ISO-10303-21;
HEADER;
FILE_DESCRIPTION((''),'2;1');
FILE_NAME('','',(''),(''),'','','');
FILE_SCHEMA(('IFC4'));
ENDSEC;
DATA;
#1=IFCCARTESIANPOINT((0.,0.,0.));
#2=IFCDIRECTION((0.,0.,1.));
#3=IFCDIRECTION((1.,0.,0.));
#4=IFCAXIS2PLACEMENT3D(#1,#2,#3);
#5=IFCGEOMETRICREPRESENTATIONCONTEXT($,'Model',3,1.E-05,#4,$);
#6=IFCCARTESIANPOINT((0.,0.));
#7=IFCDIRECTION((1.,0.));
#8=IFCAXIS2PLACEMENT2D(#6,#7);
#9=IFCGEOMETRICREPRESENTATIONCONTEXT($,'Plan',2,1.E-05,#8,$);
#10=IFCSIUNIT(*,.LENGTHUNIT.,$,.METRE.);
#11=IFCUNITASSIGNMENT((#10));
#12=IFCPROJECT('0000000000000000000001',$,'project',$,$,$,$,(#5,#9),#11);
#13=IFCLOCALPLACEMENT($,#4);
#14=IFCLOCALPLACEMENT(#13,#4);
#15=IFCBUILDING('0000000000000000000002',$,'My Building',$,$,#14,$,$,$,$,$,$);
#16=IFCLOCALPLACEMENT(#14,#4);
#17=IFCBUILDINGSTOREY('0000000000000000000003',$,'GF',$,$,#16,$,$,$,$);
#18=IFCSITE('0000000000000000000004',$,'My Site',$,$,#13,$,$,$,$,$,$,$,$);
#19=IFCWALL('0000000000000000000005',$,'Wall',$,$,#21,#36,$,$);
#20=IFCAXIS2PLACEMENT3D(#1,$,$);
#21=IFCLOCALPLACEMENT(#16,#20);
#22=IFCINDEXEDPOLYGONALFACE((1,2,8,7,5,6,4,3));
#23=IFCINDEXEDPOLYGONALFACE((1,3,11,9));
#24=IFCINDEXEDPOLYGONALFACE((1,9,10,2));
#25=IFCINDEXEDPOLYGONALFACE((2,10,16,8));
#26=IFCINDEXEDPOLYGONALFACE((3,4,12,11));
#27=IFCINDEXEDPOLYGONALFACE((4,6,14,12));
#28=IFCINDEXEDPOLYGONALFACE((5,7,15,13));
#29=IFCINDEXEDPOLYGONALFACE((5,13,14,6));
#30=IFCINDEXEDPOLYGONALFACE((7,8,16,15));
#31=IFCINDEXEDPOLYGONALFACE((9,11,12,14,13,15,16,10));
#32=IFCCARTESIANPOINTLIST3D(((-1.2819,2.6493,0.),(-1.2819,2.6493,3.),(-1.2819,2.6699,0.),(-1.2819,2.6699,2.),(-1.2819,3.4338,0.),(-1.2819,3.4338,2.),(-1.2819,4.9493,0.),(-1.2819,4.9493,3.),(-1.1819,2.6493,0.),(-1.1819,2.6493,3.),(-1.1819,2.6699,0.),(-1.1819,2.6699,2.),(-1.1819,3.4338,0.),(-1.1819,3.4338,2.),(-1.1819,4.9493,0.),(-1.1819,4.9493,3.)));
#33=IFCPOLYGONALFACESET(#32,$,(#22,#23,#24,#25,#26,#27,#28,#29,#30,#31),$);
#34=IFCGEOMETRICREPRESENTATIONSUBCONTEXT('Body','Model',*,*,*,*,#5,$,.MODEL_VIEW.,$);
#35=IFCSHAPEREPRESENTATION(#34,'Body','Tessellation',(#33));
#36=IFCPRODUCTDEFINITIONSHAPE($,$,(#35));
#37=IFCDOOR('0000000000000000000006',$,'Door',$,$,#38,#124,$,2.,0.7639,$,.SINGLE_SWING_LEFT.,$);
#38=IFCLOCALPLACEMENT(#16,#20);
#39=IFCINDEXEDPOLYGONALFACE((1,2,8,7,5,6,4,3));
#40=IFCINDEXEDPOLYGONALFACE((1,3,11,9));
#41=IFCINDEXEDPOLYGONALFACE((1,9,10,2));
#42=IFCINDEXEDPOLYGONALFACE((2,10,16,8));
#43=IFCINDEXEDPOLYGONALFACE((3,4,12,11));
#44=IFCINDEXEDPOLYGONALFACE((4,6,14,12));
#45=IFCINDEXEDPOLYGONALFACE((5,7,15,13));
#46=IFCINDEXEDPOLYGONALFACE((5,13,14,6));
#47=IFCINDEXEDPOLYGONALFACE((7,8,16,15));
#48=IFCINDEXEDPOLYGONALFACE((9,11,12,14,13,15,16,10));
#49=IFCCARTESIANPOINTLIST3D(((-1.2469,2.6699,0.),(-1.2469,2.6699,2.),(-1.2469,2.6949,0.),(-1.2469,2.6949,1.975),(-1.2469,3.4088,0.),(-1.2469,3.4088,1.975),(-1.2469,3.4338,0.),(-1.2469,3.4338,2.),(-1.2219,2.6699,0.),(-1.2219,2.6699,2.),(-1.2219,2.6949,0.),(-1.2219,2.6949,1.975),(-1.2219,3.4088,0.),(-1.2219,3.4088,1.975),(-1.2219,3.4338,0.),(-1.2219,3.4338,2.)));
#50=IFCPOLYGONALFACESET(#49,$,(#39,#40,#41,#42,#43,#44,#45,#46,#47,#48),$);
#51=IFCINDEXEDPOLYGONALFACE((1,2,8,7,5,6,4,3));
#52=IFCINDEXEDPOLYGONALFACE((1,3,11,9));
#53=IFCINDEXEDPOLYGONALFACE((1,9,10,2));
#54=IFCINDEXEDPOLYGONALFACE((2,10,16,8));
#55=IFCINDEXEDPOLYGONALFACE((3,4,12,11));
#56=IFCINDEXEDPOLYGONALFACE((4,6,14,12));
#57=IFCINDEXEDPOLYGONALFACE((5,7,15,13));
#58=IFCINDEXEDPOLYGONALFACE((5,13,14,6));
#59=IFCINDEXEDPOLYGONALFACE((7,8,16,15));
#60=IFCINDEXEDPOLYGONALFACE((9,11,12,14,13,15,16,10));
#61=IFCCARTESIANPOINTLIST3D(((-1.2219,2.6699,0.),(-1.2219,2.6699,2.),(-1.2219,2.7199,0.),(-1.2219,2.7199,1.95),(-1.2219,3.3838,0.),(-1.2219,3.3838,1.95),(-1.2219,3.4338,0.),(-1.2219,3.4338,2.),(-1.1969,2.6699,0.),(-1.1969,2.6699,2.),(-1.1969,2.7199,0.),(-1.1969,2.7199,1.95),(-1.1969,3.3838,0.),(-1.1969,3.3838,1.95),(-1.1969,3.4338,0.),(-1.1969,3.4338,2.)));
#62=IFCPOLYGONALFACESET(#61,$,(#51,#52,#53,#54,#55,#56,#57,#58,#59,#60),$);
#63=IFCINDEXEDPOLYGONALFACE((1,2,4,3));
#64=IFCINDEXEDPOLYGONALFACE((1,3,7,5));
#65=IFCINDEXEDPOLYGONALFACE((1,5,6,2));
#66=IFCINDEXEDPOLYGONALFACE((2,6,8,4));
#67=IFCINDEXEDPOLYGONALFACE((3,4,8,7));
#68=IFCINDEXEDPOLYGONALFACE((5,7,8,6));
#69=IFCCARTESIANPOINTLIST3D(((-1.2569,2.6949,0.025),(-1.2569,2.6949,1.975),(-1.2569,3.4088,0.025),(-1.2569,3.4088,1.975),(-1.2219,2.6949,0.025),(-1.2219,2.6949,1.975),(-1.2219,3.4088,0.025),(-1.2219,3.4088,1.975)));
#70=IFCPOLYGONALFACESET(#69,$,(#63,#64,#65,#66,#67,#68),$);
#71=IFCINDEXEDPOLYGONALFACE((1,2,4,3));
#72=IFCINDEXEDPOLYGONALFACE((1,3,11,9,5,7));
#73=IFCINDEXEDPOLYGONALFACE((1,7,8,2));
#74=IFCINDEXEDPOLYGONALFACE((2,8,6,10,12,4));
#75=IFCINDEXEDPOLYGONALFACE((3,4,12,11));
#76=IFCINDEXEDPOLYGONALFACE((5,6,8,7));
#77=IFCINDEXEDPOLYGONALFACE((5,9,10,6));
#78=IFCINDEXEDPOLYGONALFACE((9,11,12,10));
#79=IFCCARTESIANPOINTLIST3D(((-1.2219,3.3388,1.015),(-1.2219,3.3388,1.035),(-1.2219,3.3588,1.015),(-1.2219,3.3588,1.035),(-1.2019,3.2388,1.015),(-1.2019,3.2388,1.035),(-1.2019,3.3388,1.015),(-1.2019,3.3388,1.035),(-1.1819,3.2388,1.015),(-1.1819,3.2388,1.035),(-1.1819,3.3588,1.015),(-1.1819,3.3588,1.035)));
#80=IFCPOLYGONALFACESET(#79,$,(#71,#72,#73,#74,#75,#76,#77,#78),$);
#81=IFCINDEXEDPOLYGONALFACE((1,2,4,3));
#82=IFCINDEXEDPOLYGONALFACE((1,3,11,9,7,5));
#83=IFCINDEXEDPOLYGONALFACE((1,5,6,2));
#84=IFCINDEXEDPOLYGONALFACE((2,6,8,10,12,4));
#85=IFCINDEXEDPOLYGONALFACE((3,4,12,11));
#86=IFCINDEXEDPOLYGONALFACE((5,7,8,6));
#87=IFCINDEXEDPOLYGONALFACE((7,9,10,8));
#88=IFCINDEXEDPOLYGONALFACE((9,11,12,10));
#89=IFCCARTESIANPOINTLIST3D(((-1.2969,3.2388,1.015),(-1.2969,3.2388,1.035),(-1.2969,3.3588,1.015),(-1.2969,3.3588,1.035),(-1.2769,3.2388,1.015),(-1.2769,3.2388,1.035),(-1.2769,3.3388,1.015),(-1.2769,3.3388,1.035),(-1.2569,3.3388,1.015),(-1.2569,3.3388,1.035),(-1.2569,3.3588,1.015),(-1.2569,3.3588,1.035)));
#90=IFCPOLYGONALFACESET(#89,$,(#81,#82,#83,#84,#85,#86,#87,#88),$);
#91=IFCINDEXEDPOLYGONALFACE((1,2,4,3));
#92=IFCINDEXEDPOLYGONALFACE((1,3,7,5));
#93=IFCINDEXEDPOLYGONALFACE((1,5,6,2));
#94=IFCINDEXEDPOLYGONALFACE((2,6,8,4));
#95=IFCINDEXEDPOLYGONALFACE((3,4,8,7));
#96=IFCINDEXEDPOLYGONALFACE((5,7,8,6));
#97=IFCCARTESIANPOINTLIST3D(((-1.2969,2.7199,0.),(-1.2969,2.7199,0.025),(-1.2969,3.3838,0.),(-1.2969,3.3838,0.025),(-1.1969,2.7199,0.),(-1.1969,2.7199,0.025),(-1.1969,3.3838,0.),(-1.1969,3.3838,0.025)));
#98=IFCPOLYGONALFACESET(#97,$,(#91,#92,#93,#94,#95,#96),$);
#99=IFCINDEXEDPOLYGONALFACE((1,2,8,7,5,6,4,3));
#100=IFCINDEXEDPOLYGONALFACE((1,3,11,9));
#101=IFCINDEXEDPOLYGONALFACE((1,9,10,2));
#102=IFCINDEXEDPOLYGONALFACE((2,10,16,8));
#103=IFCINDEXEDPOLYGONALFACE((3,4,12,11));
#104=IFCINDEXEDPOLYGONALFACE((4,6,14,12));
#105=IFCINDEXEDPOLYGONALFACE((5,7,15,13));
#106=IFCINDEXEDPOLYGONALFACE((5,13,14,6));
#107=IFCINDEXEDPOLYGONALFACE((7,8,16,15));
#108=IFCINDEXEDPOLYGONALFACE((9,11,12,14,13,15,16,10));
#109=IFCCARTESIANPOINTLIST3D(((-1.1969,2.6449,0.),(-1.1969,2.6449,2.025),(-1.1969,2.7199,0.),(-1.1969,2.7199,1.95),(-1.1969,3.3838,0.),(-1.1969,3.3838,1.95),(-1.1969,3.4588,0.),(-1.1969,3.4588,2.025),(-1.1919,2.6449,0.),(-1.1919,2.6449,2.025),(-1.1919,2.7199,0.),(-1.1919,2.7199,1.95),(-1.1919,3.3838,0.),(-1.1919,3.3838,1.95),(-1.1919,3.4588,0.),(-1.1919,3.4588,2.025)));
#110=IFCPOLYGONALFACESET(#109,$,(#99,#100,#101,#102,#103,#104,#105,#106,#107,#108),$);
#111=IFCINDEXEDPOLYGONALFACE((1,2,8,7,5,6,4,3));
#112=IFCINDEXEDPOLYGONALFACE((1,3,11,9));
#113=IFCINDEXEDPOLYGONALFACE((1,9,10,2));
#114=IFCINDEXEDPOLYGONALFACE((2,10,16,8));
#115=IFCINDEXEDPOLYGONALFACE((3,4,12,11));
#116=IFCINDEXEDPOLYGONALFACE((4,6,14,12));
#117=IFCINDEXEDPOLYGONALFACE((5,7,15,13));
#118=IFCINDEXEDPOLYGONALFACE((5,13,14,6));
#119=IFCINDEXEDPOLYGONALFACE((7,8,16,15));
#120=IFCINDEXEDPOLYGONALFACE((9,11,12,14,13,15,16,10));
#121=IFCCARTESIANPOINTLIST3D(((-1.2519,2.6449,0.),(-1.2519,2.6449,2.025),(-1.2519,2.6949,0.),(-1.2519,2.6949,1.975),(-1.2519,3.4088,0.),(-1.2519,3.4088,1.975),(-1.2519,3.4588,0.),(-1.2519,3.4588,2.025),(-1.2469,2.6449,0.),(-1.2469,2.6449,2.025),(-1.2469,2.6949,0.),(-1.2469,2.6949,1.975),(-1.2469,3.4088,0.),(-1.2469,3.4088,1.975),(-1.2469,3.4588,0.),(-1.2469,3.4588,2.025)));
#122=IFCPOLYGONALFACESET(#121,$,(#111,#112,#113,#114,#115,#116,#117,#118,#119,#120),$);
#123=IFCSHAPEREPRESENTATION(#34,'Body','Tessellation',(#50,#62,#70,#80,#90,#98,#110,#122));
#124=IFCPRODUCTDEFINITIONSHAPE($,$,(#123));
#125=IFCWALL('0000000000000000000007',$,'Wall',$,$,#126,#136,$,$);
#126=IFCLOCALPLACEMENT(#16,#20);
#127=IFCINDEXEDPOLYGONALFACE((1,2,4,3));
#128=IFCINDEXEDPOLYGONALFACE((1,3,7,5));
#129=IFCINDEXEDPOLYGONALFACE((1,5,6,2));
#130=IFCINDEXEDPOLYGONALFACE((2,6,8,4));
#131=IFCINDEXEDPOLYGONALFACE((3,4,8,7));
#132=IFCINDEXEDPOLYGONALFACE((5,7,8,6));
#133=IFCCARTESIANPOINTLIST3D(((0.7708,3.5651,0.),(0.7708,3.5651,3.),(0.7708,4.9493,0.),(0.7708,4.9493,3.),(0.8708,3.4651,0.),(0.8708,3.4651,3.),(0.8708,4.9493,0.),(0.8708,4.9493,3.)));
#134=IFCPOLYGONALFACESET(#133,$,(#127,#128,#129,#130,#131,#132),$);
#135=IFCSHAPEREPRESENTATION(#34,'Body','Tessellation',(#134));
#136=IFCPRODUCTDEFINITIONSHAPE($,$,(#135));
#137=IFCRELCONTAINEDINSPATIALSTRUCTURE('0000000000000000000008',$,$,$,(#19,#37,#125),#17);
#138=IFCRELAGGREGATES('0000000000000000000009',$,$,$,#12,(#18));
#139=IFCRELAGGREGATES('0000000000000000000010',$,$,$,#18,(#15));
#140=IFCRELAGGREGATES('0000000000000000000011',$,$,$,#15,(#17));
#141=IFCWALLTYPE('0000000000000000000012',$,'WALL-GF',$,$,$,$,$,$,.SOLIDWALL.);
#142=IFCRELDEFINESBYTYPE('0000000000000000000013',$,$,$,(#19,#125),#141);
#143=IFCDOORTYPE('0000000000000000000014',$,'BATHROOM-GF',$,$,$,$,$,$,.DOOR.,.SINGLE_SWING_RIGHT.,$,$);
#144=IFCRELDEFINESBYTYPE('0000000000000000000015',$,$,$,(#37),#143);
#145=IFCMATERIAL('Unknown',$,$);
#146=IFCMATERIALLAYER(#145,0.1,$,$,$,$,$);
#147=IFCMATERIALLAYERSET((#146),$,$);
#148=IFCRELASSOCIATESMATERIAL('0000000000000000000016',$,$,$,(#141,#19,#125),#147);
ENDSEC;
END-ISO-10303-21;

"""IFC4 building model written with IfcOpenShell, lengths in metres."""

from ifc_helpers import new_model, entity, si_unit, frame, origin_with_axes, origin_2d_with_axis, place, context, subcontext, project, spatial, line, indexed_curve, outline, extrude, shape, source, transform, mapped, material, layer, layer_set, layer_usage, type_object, type_shapes, element, fill, save


model = new_model("IFC4")

# Units and contexts
model_context = context("Model", 3, precision=1e-05, world=origin_with_axes())
plan_context = context("Plan", 2, precision=1e-05, world=origin_2d_with_axis())
body_context_1 = subcontext(model_context, "Body", "Model", "MODEL_VIEW")
body_context_2 = subcontext(plan_context, "Body", "Plan", "PLAN_VIEW")
ifc_project = project(units=[si_unit("LENGTHUNIT", "METRE")], contexts=[model_context, plan_context])

# Site, building, storey
site_placement = place(None, origin_with_axes())
site = spatial("IfcSite", under=ifc_project, at=site_placement, Name="My Site")
building_placement = place(site_placement, origin_with_axes())
building = spatial("IfcBuilding", under=site, at=building_placement, Name="My Building")
storey_placement = place(building_placement, origin_with_axes())
storey = spatial("IfcBuildingStorey", under=building, at=storey_placement, Name="GF")

# Shared definitions
ifc_material_1 = material(Name="Unknown")

# Shared definitions
ifc_layer_1 = layer(ifc_material_1, 0.1)
ifc_layer_set_1 = layer_set([ifc_layer_1])
wall_type = type_object("IfcWallType", Name="WALL-GF", PredefinedType="SOLIDWALL", material=ifc_layer_set_1)

# Wall, opening, door
ifc_layer_usage_1 = layer_usage(ifc_layer_set_1, "AXIS2", "POSITIVE", 0.0)
wall_1_placement = place(storey_placement, frame((-1.1819, 2.6493, 0.0), z_axis=(0.0, 0.0, 1.0), x_axis=(0.0, 1.0, 0.0)))
wall_1 = element("IfcWall", 1, at=wall_1_placement, inside=storey, type_object=wall_type, material=ifc_layer_usage_1, Name="Wall", context=body_context_1, shape_type="SweptSolid", body=[
    extrude(outline(indexed_curve([(0.0, 0.0), (0.0, 0.1), (2.3, 0.1), (2.3, 0.0)], segments=[line(1, 2, 3, 4, 1)])), origin_with_axes(), (0.0, 0.0, 1.0), 3.0),
])
shared_shape_1 = source(origin_with_axes(), body_context_1, "Body", "SweptSolid", [
    extrude(outline(indexed_curve([(0.0, 0.0), (0.7639, 0.0), (0.7639, 2.0), (0.0, 2.0)], segments=[line(1, 2, 3, 4, 1)])), frame((0.0, -0.6, 0.0), z_axis=(0.0, -1.0, 0.0), x_axis=(1.0, 0.0, 0.0)), (0.0, 0.0, -1.0), 1.2),
])
opening_1_placement = place(wall_1_placement, frame((0.0206, 0.015, 0.0), z_axis=(0.0, 0.0, 1.0), x_axis=(1.0, 0.0, 0.0)))
opening_1 = element("IfcOpeningElement", 2, at=opening_1_placement, cuts=wall_1, PredefinedType="OPENING", context=body_context_1, shape_type="MappedRepresentation", body=[
    mapped(shared_shape_1, transform((0.0, 0.0, 0.0), x_axis=(1.0, 0.0, 0.0), y_axis=(0.0, 1.0, 0.0), z_axis=(0.0, 0.0, 1.0), scale=1.0)),
])
door_type_1 = type_object("IfcDoorType", Name="BATHROOM-GF", OperationType="SINGLE_SWING_RIGHT", PredefinedType="DOOR")
shared_shape_2 = source(origin_with_axes(), body_context_1, "Body", "SweptSolid", [
    extrude(outline(indexed_curve([(0.0, 0.0), (0.0, 2.0), (0.7639, 2.0), (0.7639, 0.0), (0.7389, 0.0), (0.7389, 1.975), (0.025, 1.975), (0.025, 0.0)], segments=[line(1, 2, 3, 4, 5, 6, 7, 8, 1)])), frame((0.0, 0.025, 0.0), z_axis=(0.0, -1.0, 0.0), x_axis=(1.0, 0.0, 0.0)), (0.0, 0.0, -1.0), 0.025),
    extrude(outline(indexed_curve([(0.0, 0.0), (0.0, 2.0), (0.7639, 2.0), (0.7639, 0.0), (0.7139, 0.0), (0.7139, 1.95), (0.05, 1.95), (0.05, 0.0)], segments=[line(1, 2, 3, 4, 5, 6, 7, 8, 1)])), frame((0.0, 0.0, 0.0), z_axis=(0.0, -1.0, 0.0), x_axis=(1.0, 0.0, 0.0)), (0.0, 0.0, -1.0), 0.025),
    extrude(outline(indexed_curve([(0.0, 0.0), (0.7139, 0.0), (0.7139, 0.035), (0.0, 0.035)], segments=[line(1, 2, 3, 4, 1)])), frame((0.025, 0.025, 0.025), z_axis=(0.0, 0.0, 1.0), x_axis=(1.0, 0.0, 0.0)), (0.0, 0.0, 1.0), 1.95),
    extrude(outline(indexed_curve([(0.0, 0.0), (0.0, -0.04), (-0.12, -0.04), (-0.12, -0.02), (-0.02, -0.02), (-0.02, 0.0)], segments=[line(1, 2, 3, 4, 5, 6, 1)])), frame((0.6889, 0.025, 1.015), z_axis=(0.0, 0.0, 1.0), x_axis=(1.0, 0.0, 0.0)), (0.0, 0.0, 1.0), 0.02),
    extrude(outline(indexed_curve([(0.0, 0.0), (0.0, 0.04), (-0.12, 0.04), (-0.12, 0.02), (-0.02, 0.02), (-0.02, 0.0)], segments=[line(1, 2, 3, 4, 5, 6, 1)])), frame((0.6889, 0.06, 1.015), z_axis=(0.0, 0.0, 1.0), x_axis=(1.0, 0.0, 0.0)), (0.0, 0.0, 1.0), 0.02),
    extrude(outline(indexed_curve([(0.0, 0.0), (0.6639, 0.0), (0.6639, 0.1), (0.0, 0.1)], segments=[line(1, 2, 3, 4, 1)])), frame((0.05, 0.0, 0.0), z_axis=(0.0, 0.0, 1.0), x_axis=(1.0, 0.0, 0.0)), (0.0, 0.0, 1.0), 0.025),
    extrude(outline(indexed_curve([(0.0, 0.0), (0.0, 2.025), (0.8139, 2.025), (0.8139, 0.0), (0.7389, 0.0), (0.7389, 1.95), (0.075, 1.95), (0.075, 0.0)], segments=[line(1, 2, 3, 4, 5, 6, 7, 8, 1)])), frame((-0.025, -0.005, 0.0), z_axis=(0.0, -1.0, 0.0), x_axis=(1.0, 0.0, 0.0)), (0.0, 0.0, -1.0), 0.005),
    extrude(outline(indexed_curve([(0.0, 0.0), (0.0, 2.025), (0.8139, 2.025), (0.8139, 0.0), (0.7639, 0.0), (0.7639, 1.975), (0.05, 1.975), (0.05, 0.0)], segments=[line(1, 2, 3, 4, 5, 6, 7, 8, 1)])), frame((-0.025, 0.05, 0.0), z_axis=(0.0, -1.0, 0.0), x_axis=(1.0, 0.0, 0.0)), (0.0, 0.0, -1.0), 0.005),
])
shared_shape_3 = source(origin_with_axes(), body_context_2, "Body", "Curve2D", [
    entity("IfcIndexedPolyCurve", entity("IfcCartesianPointList2D", [[0.0, 0.0], [0.0, 0.05], [0.025, 0.05], [0.025, 0.025], [0.05, 0.025], [0.05, 0.0]]), [entity("IfcLineIndex", [1, 2, 3, 4, 5, 6, 1])]),
    entity("IfcIndexedPolyCurve", entity("IfcCartesianPointList2D", [[0.7639, 0.0], [0.7639, 0.05], [0.7389, 0.05], [0.7389, 0.025], [0.7139, 0.025], [0.7139, 0.0]]), [entity("IfcLineIndex", [1, 2, 3, 4, 5, 6, 1])]),
    entity("IfcTrimmedCurve", entity("IfcEllipse", entity("IfcAxis2Placement2D", entity("IfcCartesianPoint", [0.06, 0.05]), entity("IfcDirection", [1.0, 0.0])), 0.6789, 0.7139), [entity("IfcCartesianPoint", [0.7389, 0.05])], [entity("IfcCartesianPoint", [0.06, 0.7639])], True, "CARTESIAN"),
    entity("IfcIndexedPolyCurve", entity("IfcCartesianPointList2D", [[0.025, 0.05], [0.06, 0.05], [0.06, 0.7639], [0.025, 0.7639]]), [entity("IfcLineIndex", [1, 2, 3, 4, 1])]),
])
type_shapes(door_type_1, [shared_shape_2, shared_shape_3])
door_1_placement = place(opening_1_placement, origin_with_axes())
door_1 = element("IfcDoor", 3, at=door_1_placement, inside=storey, type_object=door_type_1, Name="Door", OperationType="SINGLE_SWING_LEFT", OverallHeight=2.0, OverallWidth=0.7639, shapes=[
    shape(body_context_1, "Body", "MappedRepresentation", [mapped(shared_shape_2, transform((0.0, 0.0, 0.0), x_axis=(1.0, 0.0, 0.0), y_axis=(0.0, 1.0, 0.0), z_axis=(0.0, 0.0, 1.0), scale=1.0))]),
    shape(body_context_2, "Body", "MappedRepresentation", [mapped(shared_shape_3, transform((0.0, 0.0, 0.0), x_axis=(1.0, 0.0, 0.0), y_axis=(0.0, 1.0, 0.0), z_axis=(0.0, 0.0, 1.0), scale=1.0))]),
])
fill(opening_1, door_1)

# Wall
ifc_layer_usage_2 = layer_usage(ifc_layer_set_1, "AXIS2", "POSITIVE", 0.0)
wall_2_placement = place(storey_placement, frame((0.7708, 5.0493, 0.0), z_axis=(0.0, 0.0, 1.0), x_axis=(0.0, -1.0, 0.0)))
element("IfcWall", 4, at=wall_2_placement, inside=storey, type_object=wall_type, material=ifc_layer_usage_2, Name="Wall", context=body_context_1, shape_type="SweptSolid", body=[
    extrude(outline(indexed_curve([(0.1, 0.0), (0.1, 0.1), (1.5842, 0.1), (1.4842, 0.0)], segments=[line(1, 2, 3, 4, 1)])), origin_with_axes(), (0.0, 0.0, 1.0), 3.0),
])

save(model, "model.ifc")
